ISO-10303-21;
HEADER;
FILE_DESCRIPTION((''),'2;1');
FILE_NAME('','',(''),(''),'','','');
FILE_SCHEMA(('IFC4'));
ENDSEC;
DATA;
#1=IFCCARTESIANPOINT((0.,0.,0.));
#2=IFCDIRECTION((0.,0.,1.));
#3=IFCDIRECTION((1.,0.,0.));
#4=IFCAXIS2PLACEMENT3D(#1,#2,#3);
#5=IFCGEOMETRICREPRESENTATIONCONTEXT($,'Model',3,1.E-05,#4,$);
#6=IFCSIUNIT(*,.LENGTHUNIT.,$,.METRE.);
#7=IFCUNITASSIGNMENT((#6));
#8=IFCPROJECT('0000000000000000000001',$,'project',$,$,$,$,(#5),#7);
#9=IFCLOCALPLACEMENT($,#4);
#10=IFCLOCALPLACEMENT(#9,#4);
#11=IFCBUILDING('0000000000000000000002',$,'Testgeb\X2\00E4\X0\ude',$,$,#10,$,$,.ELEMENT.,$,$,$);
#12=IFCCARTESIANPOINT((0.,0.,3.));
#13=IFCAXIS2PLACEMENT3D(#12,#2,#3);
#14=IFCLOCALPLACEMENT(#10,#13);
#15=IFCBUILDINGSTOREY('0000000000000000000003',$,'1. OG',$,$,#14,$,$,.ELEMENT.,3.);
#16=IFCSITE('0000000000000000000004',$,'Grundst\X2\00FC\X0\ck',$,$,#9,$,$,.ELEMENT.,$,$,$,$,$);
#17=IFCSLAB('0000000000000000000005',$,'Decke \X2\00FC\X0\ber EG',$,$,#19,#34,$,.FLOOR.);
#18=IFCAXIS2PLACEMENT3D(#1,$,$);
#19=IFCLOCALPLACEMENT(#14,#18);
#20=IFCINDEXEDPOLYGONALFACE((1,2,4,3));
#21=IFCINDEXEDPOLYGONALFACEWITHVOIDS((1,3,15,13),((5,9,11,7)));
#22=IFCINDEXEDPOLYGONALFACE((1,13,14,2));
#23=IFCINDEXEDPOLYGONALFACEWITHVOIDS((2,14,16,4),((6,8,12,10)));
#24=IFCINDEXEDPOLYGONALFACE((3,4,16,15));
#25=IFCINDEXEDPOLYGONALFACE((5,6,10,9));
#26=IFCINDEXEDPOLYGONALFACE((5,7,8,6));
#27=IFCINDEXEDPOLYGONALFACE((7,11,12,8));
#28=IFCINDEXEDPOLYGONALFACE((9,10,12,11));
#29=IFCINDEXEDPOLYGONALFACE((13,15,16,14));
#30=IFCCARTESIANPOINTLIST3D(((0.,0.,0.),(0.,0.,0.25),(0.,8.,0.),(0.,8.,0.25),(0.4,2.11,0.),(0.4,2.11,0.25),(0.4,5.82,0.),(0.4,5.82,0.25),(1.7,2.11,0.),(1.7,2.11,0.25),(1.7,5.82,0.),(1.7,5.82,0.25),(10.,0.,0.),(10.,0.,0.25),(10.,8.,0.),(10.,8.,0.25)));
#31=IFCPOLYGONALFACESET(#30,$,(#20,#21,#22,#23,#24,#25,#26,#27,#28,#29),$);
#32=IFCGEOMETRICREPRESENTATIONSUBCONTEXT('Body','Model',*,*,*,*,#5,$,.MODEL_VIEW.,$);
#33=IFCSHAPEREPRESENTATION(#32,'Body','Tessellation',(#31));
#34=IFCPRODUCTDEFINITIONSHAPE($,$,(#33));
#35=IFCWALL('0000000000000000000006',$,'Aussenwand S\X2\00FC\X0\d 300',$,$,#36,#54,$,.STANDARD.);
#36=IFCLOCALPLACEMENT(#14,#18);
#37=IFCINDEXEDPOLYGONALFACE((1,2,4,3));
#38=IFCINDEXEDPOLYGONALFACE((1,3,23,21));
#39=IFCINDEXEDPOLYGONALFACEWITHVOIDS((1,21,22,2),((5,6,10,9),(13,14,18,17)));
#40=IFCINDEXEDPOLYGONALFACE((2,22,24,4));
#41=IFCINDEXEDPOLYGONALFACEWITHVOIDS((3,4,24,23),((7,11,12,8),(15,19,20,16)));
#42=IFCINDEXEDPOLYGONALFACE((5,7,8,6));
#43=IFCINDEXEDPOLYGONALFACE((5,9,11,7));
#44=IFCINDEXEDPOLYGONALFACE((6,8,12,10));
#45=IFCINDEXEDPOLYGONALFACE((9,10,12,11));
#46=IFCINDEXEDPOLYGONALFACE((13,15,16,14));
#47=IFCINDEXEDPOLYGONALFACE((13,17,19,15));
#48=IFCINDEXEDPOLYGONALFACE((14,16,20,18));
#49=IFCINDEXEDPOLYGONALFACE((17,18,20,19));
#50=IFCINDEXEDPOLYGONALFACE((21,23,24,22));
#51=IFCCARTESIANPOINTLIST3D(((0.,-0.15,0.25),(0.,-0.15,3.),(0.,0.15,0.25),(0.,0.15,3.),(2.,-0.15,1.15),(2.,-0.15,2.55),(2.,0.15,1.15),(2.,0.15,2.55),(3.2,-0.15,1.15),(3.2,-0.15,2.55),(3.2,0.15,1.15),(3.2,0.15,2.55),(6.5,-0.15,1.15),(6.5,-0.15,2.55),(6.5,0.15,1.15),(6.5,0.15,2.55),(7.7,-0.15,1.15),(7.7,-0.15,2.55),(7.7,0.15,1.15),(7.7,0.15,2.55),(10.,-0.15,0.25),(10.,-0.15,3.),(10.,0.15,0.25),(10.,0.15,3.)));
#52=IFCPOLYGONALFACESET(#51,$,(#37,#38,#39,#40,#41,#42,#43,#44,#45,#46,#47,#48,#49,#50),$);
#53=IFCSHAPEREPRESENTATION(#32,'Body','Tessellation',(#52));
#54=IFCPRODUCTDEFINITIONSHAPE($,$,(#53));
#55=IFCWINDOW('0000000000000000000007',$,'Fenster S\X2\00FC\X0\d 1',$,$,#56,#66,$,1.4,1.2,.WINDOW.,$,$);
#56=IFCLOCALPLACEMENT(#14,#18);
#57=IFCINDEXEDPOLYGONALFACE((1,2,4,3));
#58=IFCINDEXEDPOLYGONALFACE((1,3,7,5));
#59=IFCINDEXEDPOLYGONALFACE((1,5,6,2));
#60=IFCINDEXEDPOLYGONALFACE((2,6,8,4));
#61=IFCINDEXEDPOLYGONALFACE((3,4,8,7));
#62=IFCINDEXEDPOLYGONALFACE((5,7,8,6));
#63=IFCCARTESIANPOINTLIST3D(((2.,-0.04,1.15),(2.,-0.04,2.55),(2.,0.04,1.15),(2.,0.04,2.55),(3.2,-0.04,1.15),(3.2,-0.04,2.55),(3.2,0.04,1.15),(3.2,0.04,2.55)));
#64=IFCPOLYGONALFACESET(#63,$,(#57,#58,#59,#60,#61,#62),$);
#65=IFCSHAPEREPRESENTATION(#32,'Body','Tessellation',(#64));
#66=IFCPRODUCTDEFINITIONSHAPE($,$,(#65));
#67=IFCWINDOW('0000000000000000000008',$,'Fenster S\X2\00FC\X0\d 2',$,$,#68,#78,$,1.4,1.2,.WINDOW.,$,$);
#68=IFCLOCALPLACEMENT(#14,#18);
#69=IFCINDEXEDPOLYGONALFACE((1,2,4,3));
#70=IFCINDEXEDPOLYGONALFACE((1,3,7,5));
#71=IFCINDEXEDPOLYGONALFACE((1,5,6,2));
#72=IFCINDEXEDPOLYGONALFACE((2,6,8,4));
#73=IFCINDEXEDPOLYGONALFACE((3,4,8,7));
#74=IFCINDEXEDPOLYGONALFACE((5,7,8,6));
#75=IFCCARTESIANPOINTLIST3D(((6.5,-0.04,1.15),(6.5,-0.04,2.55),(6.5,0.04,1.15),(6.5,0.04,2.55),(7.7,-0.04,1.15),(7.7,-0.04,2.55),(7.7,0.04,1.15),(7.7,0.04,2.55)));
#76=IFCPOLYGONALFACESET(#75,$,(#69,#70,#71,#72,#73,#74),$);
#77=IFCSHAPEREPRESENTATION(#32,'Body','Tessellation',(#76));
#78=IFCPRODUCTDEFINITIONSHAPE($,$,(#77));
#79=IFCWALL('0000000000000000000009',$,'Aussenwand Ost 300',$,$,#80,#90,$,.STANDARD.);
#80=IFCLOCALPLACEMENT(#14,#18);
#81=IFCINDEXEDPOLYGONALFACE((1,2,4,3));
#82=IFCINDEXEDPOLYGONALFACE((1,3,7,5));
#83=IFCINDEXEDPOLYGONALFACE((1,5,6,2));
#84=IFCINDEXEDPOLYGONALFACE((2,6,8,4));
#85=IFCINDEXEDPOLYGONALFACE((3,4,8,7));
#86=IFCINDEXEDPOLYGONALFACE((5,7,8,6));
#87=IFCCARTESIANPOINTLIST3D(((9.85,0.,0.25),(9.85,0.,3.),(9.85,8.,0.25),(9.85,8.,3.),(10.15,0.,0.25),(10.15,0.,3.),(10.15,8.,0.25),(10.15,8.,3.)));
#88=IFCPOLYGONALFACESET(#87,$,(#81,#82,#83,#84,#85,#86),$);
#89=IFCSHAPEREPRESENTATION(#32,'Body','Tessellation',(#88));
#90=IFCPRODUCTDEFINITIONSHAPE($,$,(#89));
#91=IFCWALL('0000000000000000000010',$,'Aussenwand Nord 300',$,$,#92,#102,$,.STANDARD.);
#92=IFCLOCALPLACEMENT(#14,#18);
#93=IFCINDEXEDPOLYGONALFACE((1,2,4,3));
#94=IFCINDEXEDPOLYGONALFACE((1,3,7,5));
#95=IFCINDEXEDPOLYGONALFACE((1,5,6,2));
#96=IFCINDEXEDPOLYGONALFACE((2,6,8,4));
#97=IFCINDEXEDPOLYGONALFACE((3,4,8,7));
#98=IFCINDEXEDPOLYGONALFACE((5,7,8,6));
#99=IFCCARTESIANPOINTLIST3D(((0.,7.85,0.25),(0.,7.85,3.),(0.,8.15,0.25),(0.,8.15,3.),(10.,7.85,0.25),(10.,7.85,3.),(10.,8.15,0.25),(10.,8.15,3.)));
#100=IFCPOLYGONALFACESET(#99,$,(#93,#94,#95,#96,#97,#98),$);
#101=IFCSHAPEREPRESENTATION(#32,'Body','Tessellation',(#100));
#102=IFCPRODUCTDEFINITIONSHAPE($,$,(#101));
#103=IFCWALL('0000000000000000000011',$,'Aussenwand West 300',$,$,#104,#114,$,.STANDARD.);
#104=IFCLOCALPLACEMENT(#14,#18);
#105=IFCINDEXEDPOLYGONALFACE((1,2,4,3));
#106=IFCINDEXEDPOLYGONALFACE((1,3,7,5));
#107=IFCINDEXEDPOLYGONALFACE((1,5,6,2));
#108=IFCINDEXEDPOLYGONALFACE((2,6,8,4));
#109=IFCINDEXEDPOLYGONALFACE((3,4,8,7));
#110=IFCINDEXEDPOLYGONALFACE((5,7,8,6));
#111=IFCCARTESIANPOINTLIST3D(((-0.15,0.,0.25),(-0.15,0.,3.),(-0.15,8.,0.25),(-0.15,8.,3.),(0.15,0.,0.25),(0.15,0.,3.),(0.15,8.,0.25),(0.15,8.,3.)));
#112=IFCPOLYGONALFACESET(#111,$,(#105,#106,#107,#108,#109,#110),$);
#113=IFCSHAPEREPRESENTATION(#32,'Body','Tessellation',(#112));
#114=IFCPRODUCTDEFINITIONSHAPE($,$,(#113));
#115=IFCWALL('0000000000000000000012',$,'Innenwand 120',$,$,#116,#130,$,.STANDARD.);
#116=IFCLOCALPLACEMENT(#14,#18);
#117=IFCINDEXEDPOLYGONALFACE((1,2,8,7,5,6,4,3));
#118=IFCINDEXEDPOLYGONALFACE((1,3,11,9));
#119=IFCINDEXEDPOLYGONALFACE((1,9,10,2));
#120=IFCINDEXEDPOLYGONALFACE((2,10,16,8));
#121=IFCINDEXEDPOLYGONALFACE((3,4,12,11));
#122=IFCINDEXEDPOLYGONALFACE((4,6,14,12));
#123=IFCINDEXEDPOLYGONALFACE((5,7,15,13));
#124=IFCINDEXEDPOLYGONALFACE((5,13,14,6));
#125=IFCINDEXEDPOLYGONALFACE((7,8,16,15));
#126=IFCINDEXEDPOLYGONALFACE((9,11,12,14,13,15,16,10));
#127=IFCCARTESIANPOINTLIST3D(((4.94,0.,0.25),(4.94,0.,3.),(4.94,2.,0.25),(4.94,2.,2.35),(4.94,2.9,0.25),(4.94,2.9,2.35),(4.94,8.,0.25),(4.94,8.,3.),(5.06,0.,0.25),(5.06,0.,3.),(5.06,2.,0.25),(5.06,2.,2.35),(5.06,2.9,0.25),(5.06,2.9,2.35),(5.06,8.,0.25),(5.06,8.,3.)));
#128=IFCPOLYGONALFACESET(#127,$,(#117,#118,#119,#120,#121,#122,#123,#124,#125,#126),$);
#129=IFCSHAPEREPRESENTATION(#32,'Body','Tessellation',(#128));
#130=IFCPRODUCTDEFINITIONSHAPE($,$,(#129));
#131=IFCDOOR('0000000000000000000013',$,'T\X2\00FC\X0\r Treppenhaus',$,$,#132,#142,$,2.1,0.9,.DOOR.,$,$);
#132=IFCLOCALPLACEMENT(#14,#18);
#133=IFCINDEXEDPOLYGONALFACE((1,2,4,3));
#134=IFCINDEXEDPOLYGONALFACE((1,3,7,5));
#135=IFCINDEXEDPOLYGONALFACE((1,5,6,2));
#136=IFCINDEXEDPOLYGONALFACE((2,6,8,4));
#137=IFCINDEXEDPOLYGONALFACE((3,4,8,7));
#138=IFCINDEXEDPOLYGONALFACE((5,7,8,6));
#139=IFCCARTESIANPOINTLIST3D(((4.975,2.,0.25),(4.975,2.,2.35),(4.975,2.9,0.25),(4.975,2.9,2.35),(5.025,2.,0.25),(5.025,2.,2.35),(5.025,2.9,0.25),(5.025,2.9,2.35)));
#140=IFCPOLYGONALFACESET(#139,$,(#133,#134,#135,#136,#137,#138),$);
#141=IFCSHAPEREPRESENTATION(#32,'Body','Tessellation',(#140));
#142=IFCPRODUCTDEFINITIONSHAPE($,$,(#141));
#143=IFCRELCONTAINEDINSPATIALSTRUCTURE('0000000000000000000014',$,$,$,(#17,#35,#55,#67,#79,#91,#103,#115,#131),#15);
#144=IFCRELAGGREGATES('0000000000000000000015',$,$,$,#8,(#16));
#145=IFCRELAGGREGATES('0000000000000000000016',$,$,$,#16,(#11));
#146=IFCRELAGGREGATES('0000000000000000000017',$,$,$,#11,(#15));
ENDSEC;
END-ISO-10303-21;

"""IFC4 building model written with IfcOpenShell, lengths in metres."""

from ifc_helpers import new_model, si_unit, frame, frame_2d, origin_with_axes, place, context, subcontext, project, spatial, rectangle, extrude, element, fill, save


model = new_model("IFC4")

# Units and contexts
model_context = context("Model", 3, precision=1e-05, world=origin_with_axes())
body_context = subcontext(model_context, "Body", "Model", "MODEL_VIEW")
ifc_project = project(units=[si_unit("LENGTHUNIT", "METRE")], contexts=[model_context])

# Site, building, storey
site_placement = place(None, origin_with_axes())
site = spatial("IfcSite", under=ifc_project, at=site_placement, Name="Grundstück", CompositionType="ELEMENT")
building_placement = place(site_placement, origin_with_axes())
building = spatial("IfcBuilding", under=site, at=building_placement, Name="Testgebäude", CompositionType="ELEMENT")
storey_placement = place(building_placement, frame((0.0, 0.0, 3.0), z_axis=(0.0, 0.0, 1.0), x_axis=(1.0, 0.0, 0.0)))
storey = spatial("IfcBuildingStorey", under=building, at=storey_placement, Name="1. OG", CompositionType="ELEMENT", Elevation=3.0)

# Slab, opening
slab_placement = place(storey_placement, origin_with_axes())
slab = element("IfcSlab", 1, at=slab_placement, inside=storey, Name="Decke über EG", PredefinedType="FLOOR", context=body_context, shape_type="SweptSolid", body=[
    extrude(rectangle(XDim=10.0, YDim=8.0, at=frame_2d((5.0, 4.0))), origin_with_axes(), (0.0, 0.0, 1.0), 0.25),
])
opening_1_placement = place(storey_placement, frame((0.4, 2.11, -0.05), z_axis=(0.0, 0.0, 1.0), x_axis=(1.0, 0.0, 0.0)))
element("IfcOpeningElement", 2, at=opening_1_placement, cuts=slab, PredefinedType="OPENING", context=body_context, shape_type="SweptSolid", body=[
    extrude(rectangle(XDim=1.3, YDim=3.71, at=frame_2d((0.65, 1.855))), origin_with_axes(), (0.0, 0.0, 1.0), 0.35),
])

# Wall, openings, windows
wall_1_placement = place(storey_placement, frame((0.0, 0.0, 0.25), z_axis=(0.0, 0.0, 1.0), x_axis=(1.0, 0.0, 0.0)))
wall_1 = element("IfcWall", 3, at=wall_1_placement, inside=storey, Name="Aussenwand Süd 300", PredefinedType="STANDARD", context=body_context, shape_type="SweptSolid", body=[
    extrude(rectangle(XDim=10.0, YDim=0.3, at=frame_2d((5.0, 0.0))), origin_with_axes(), (0.0, 0.0, 1.0), 2.75),
])
opening_2_placement = place(storey_placement, frame((2.0, 0.0, 1.15), z_axis=(0.0, 0.0, 1.0), x_axis=(1.0, 0.0, 0.0)))
opening_2 = element("IfcOpeningElement", 4, at=opening_2_placement, cuts=wall_1, PredefinedType="OPENING", context=body_context, shape_type="SweptSolid", body=[
    extrude(rectangle(XDim=1.2, YDim=0.5, at=frame_2d((0.6, 0.0))), origin_with_axes(), (0.0, 0.0, 1.0), 1.4),
])
opening_3_placement = place(storey_placement, frame((6.5, 0.0, 1.15), z_axis=(0.0, 0.0, 1.0), x_axis=(1.0, 0.0, 0.0)))
opening_3 = element("IfcOpeningElement", 5, at=opening_3_placement, cuts=wall_1, PredefinedType="OPENING", context=body_context, shape_type="SweptSolid", body=[
    extrude(rectangle(XDim=1.2, YDim=0.5, at=frame_2d((0.6, 0.0))), origin_with_axes(), (0.0, 0.0, 1.0), 1.4),
])
window_1_placement = place(storey_placement, frame((2.0, 0.0, 1.15), z_axis=(0.0, 0.0, 1.0), x_axis=(1.0, 0.0, 0.0)))
window_1 = element("IfcWindow", 6, at=window_1_placement, inside=storey, Name="Fenster Süd 1", OverallHeight=1.4, OverallWidth=1.2, PredefinedType="WINDOW", context=body_context, shape_type="SweptSolid", body=[
    extrude(rectangle(XDim=1.2, YDim=0.08, at=frame_2d((0.6, 0.0))), origin_with_axes(), (0.0, 0.0, 1.0), 1.4),
])
fill(opening_2, window_1)
window_2_placement = place(storey_placement, frame((6.5, 0.0, 1.15), z_axis=(0.0, 0.0, 1.0), x_axis=(1.0, 0.0, 0.0)))
window_2 = element("IfcWindow", 7, at=window_2_placement, inside=storey, Name="Fenster Süd 2", OverallHeight=1.4, OverallWidth=1.2, PredefinedType="WINDOW", context=body_context, shape_type="SweptSolid", body=[
    extrude(rectangle(XDim=1.2, YDim=0.08, at=frame_2d((0.6, 0.0))), origin_with_axes(), (0.0, 0.0, 1.0), 1.4),
])
fill(opening_3, window_2)

# Walls
wall_2_placement = place(storey_placement, frame((10.0, 0.0, 0.25), z_axis=(0.0, 0.0, 1.0), x_axis=(0.0, 1.0, 0.0)))
element("IfcWall", 8, at=wall_2_placement, inside=storey, Name="Aussenwand Ost 300", PredefinedType="STANDARD", context=body_context, shape_type="SweptSolid", body=[
    extrude(rectangle(XDim=8.0, YDim=0.3, at=frame_2d((4.0, 0.0))), origin_with_axes(), (0.0, 0.0, 1.0), 2.75),
])
wall_3_placement = place(storey_placement, frame((10.0, 8.0, 0.25), z_axis=(0.0, 0.0, 1.0), x_axis=(-1.0, 0.0, 0.0)))
element("IfcWall", 9, at=wall_3_placement, inside=storey, Name="Aussenwand Nord 300", PredefinedType="STANDARD", context=body_context, shape_type="SweptSolid", body=[
    extrude(rectangle(XDim=10.0, YDim=0.3, at=frame_2d((5.0, 0.0))), origin_with_axes(), (0.0, 0.0, 1.0), 2.75),
])
wall_4_placement = place(storey_placement, frame((0.0, 8.0, 0.25), z_axis=(0.0, 0.0, 1.0), x_axis=(0.0, -1.0, 0.0)))
element("IfcWall", 10, at=wall_4_placement, inside=storey, Name="Aussenwand West 300", PredefinedType="STANDARD", context=body_context, shape_type="SweptSolid", body=[
    extrude(rectangle(XDim=8.0, YDim=0.3, at=frame_2d((4.0, 0.0))), origin_with_axes(), (0.0, 0.0, 1.0), 2.75),
])

# Wall, opening, door
wall_5_placement = place(storey_placement, frame((5.0, 0.0, 0.25), z_axis=(0.0, 0.0, 1.0), x_axis=(0.0, 1.0, 0.0)))
wall_5 = element("IfcWall", 11, at=wall_5_placement, inside=storey, Name="Innenwand 120", PredefinedType="STANDARD", context=body_context, shape_type="SweptSolid", body=[
    extrude(rectangle(XDim=8.0, YDim=0.12, at=frame_2d((4.0, 0.0))), origin_with_axes(), (0.0, 0.0, 1.0), 2.75),
])
opening_4_placement = place(storey_placement, frame((5.0, 2.0, 0.25), z_axis=(0.0, 0.0, 1.0), x_axis=(0.0, 1.0, 0.0)))
opening_4 = element("IfcOpeningElement", 12, at=opening_4_placement, cuts=wall_5, PredefinedType="OPENING", context=body_context, shape_type="SweptSolid", body=[
    extrude(rectangle(XDim=0.9, YDim=0.4, at=frame_2d((0.45, 0.0))), origin_with_axes(), (0.0, 0.0, 1.0), 2.1),
])
door_placement = place(storey_placement, frame((5.0, 2.0, 0.25), z_axis=(0.0, 0.0, 1.0), x_axis=(0.0, 1.0, 0.0)))
door = element("IfcDoor", 13, at=door_placement, inside=storey, Name="Tür Treppenhaus", OverallHeight=2.1, OverallWidth=0.9, PredefinedType="DOOR", context=body_context, shape_type="SweptSolid", body=[
    extrude(rectangle(XDim=0.9, YDim=0.05, at=frame_2d((0.45, 0.0))), origin_with_axes(), (0.0, 0.0, 1.0), 2.1),
])
fill(opening_4, door)

save(model, "model.ifc")
